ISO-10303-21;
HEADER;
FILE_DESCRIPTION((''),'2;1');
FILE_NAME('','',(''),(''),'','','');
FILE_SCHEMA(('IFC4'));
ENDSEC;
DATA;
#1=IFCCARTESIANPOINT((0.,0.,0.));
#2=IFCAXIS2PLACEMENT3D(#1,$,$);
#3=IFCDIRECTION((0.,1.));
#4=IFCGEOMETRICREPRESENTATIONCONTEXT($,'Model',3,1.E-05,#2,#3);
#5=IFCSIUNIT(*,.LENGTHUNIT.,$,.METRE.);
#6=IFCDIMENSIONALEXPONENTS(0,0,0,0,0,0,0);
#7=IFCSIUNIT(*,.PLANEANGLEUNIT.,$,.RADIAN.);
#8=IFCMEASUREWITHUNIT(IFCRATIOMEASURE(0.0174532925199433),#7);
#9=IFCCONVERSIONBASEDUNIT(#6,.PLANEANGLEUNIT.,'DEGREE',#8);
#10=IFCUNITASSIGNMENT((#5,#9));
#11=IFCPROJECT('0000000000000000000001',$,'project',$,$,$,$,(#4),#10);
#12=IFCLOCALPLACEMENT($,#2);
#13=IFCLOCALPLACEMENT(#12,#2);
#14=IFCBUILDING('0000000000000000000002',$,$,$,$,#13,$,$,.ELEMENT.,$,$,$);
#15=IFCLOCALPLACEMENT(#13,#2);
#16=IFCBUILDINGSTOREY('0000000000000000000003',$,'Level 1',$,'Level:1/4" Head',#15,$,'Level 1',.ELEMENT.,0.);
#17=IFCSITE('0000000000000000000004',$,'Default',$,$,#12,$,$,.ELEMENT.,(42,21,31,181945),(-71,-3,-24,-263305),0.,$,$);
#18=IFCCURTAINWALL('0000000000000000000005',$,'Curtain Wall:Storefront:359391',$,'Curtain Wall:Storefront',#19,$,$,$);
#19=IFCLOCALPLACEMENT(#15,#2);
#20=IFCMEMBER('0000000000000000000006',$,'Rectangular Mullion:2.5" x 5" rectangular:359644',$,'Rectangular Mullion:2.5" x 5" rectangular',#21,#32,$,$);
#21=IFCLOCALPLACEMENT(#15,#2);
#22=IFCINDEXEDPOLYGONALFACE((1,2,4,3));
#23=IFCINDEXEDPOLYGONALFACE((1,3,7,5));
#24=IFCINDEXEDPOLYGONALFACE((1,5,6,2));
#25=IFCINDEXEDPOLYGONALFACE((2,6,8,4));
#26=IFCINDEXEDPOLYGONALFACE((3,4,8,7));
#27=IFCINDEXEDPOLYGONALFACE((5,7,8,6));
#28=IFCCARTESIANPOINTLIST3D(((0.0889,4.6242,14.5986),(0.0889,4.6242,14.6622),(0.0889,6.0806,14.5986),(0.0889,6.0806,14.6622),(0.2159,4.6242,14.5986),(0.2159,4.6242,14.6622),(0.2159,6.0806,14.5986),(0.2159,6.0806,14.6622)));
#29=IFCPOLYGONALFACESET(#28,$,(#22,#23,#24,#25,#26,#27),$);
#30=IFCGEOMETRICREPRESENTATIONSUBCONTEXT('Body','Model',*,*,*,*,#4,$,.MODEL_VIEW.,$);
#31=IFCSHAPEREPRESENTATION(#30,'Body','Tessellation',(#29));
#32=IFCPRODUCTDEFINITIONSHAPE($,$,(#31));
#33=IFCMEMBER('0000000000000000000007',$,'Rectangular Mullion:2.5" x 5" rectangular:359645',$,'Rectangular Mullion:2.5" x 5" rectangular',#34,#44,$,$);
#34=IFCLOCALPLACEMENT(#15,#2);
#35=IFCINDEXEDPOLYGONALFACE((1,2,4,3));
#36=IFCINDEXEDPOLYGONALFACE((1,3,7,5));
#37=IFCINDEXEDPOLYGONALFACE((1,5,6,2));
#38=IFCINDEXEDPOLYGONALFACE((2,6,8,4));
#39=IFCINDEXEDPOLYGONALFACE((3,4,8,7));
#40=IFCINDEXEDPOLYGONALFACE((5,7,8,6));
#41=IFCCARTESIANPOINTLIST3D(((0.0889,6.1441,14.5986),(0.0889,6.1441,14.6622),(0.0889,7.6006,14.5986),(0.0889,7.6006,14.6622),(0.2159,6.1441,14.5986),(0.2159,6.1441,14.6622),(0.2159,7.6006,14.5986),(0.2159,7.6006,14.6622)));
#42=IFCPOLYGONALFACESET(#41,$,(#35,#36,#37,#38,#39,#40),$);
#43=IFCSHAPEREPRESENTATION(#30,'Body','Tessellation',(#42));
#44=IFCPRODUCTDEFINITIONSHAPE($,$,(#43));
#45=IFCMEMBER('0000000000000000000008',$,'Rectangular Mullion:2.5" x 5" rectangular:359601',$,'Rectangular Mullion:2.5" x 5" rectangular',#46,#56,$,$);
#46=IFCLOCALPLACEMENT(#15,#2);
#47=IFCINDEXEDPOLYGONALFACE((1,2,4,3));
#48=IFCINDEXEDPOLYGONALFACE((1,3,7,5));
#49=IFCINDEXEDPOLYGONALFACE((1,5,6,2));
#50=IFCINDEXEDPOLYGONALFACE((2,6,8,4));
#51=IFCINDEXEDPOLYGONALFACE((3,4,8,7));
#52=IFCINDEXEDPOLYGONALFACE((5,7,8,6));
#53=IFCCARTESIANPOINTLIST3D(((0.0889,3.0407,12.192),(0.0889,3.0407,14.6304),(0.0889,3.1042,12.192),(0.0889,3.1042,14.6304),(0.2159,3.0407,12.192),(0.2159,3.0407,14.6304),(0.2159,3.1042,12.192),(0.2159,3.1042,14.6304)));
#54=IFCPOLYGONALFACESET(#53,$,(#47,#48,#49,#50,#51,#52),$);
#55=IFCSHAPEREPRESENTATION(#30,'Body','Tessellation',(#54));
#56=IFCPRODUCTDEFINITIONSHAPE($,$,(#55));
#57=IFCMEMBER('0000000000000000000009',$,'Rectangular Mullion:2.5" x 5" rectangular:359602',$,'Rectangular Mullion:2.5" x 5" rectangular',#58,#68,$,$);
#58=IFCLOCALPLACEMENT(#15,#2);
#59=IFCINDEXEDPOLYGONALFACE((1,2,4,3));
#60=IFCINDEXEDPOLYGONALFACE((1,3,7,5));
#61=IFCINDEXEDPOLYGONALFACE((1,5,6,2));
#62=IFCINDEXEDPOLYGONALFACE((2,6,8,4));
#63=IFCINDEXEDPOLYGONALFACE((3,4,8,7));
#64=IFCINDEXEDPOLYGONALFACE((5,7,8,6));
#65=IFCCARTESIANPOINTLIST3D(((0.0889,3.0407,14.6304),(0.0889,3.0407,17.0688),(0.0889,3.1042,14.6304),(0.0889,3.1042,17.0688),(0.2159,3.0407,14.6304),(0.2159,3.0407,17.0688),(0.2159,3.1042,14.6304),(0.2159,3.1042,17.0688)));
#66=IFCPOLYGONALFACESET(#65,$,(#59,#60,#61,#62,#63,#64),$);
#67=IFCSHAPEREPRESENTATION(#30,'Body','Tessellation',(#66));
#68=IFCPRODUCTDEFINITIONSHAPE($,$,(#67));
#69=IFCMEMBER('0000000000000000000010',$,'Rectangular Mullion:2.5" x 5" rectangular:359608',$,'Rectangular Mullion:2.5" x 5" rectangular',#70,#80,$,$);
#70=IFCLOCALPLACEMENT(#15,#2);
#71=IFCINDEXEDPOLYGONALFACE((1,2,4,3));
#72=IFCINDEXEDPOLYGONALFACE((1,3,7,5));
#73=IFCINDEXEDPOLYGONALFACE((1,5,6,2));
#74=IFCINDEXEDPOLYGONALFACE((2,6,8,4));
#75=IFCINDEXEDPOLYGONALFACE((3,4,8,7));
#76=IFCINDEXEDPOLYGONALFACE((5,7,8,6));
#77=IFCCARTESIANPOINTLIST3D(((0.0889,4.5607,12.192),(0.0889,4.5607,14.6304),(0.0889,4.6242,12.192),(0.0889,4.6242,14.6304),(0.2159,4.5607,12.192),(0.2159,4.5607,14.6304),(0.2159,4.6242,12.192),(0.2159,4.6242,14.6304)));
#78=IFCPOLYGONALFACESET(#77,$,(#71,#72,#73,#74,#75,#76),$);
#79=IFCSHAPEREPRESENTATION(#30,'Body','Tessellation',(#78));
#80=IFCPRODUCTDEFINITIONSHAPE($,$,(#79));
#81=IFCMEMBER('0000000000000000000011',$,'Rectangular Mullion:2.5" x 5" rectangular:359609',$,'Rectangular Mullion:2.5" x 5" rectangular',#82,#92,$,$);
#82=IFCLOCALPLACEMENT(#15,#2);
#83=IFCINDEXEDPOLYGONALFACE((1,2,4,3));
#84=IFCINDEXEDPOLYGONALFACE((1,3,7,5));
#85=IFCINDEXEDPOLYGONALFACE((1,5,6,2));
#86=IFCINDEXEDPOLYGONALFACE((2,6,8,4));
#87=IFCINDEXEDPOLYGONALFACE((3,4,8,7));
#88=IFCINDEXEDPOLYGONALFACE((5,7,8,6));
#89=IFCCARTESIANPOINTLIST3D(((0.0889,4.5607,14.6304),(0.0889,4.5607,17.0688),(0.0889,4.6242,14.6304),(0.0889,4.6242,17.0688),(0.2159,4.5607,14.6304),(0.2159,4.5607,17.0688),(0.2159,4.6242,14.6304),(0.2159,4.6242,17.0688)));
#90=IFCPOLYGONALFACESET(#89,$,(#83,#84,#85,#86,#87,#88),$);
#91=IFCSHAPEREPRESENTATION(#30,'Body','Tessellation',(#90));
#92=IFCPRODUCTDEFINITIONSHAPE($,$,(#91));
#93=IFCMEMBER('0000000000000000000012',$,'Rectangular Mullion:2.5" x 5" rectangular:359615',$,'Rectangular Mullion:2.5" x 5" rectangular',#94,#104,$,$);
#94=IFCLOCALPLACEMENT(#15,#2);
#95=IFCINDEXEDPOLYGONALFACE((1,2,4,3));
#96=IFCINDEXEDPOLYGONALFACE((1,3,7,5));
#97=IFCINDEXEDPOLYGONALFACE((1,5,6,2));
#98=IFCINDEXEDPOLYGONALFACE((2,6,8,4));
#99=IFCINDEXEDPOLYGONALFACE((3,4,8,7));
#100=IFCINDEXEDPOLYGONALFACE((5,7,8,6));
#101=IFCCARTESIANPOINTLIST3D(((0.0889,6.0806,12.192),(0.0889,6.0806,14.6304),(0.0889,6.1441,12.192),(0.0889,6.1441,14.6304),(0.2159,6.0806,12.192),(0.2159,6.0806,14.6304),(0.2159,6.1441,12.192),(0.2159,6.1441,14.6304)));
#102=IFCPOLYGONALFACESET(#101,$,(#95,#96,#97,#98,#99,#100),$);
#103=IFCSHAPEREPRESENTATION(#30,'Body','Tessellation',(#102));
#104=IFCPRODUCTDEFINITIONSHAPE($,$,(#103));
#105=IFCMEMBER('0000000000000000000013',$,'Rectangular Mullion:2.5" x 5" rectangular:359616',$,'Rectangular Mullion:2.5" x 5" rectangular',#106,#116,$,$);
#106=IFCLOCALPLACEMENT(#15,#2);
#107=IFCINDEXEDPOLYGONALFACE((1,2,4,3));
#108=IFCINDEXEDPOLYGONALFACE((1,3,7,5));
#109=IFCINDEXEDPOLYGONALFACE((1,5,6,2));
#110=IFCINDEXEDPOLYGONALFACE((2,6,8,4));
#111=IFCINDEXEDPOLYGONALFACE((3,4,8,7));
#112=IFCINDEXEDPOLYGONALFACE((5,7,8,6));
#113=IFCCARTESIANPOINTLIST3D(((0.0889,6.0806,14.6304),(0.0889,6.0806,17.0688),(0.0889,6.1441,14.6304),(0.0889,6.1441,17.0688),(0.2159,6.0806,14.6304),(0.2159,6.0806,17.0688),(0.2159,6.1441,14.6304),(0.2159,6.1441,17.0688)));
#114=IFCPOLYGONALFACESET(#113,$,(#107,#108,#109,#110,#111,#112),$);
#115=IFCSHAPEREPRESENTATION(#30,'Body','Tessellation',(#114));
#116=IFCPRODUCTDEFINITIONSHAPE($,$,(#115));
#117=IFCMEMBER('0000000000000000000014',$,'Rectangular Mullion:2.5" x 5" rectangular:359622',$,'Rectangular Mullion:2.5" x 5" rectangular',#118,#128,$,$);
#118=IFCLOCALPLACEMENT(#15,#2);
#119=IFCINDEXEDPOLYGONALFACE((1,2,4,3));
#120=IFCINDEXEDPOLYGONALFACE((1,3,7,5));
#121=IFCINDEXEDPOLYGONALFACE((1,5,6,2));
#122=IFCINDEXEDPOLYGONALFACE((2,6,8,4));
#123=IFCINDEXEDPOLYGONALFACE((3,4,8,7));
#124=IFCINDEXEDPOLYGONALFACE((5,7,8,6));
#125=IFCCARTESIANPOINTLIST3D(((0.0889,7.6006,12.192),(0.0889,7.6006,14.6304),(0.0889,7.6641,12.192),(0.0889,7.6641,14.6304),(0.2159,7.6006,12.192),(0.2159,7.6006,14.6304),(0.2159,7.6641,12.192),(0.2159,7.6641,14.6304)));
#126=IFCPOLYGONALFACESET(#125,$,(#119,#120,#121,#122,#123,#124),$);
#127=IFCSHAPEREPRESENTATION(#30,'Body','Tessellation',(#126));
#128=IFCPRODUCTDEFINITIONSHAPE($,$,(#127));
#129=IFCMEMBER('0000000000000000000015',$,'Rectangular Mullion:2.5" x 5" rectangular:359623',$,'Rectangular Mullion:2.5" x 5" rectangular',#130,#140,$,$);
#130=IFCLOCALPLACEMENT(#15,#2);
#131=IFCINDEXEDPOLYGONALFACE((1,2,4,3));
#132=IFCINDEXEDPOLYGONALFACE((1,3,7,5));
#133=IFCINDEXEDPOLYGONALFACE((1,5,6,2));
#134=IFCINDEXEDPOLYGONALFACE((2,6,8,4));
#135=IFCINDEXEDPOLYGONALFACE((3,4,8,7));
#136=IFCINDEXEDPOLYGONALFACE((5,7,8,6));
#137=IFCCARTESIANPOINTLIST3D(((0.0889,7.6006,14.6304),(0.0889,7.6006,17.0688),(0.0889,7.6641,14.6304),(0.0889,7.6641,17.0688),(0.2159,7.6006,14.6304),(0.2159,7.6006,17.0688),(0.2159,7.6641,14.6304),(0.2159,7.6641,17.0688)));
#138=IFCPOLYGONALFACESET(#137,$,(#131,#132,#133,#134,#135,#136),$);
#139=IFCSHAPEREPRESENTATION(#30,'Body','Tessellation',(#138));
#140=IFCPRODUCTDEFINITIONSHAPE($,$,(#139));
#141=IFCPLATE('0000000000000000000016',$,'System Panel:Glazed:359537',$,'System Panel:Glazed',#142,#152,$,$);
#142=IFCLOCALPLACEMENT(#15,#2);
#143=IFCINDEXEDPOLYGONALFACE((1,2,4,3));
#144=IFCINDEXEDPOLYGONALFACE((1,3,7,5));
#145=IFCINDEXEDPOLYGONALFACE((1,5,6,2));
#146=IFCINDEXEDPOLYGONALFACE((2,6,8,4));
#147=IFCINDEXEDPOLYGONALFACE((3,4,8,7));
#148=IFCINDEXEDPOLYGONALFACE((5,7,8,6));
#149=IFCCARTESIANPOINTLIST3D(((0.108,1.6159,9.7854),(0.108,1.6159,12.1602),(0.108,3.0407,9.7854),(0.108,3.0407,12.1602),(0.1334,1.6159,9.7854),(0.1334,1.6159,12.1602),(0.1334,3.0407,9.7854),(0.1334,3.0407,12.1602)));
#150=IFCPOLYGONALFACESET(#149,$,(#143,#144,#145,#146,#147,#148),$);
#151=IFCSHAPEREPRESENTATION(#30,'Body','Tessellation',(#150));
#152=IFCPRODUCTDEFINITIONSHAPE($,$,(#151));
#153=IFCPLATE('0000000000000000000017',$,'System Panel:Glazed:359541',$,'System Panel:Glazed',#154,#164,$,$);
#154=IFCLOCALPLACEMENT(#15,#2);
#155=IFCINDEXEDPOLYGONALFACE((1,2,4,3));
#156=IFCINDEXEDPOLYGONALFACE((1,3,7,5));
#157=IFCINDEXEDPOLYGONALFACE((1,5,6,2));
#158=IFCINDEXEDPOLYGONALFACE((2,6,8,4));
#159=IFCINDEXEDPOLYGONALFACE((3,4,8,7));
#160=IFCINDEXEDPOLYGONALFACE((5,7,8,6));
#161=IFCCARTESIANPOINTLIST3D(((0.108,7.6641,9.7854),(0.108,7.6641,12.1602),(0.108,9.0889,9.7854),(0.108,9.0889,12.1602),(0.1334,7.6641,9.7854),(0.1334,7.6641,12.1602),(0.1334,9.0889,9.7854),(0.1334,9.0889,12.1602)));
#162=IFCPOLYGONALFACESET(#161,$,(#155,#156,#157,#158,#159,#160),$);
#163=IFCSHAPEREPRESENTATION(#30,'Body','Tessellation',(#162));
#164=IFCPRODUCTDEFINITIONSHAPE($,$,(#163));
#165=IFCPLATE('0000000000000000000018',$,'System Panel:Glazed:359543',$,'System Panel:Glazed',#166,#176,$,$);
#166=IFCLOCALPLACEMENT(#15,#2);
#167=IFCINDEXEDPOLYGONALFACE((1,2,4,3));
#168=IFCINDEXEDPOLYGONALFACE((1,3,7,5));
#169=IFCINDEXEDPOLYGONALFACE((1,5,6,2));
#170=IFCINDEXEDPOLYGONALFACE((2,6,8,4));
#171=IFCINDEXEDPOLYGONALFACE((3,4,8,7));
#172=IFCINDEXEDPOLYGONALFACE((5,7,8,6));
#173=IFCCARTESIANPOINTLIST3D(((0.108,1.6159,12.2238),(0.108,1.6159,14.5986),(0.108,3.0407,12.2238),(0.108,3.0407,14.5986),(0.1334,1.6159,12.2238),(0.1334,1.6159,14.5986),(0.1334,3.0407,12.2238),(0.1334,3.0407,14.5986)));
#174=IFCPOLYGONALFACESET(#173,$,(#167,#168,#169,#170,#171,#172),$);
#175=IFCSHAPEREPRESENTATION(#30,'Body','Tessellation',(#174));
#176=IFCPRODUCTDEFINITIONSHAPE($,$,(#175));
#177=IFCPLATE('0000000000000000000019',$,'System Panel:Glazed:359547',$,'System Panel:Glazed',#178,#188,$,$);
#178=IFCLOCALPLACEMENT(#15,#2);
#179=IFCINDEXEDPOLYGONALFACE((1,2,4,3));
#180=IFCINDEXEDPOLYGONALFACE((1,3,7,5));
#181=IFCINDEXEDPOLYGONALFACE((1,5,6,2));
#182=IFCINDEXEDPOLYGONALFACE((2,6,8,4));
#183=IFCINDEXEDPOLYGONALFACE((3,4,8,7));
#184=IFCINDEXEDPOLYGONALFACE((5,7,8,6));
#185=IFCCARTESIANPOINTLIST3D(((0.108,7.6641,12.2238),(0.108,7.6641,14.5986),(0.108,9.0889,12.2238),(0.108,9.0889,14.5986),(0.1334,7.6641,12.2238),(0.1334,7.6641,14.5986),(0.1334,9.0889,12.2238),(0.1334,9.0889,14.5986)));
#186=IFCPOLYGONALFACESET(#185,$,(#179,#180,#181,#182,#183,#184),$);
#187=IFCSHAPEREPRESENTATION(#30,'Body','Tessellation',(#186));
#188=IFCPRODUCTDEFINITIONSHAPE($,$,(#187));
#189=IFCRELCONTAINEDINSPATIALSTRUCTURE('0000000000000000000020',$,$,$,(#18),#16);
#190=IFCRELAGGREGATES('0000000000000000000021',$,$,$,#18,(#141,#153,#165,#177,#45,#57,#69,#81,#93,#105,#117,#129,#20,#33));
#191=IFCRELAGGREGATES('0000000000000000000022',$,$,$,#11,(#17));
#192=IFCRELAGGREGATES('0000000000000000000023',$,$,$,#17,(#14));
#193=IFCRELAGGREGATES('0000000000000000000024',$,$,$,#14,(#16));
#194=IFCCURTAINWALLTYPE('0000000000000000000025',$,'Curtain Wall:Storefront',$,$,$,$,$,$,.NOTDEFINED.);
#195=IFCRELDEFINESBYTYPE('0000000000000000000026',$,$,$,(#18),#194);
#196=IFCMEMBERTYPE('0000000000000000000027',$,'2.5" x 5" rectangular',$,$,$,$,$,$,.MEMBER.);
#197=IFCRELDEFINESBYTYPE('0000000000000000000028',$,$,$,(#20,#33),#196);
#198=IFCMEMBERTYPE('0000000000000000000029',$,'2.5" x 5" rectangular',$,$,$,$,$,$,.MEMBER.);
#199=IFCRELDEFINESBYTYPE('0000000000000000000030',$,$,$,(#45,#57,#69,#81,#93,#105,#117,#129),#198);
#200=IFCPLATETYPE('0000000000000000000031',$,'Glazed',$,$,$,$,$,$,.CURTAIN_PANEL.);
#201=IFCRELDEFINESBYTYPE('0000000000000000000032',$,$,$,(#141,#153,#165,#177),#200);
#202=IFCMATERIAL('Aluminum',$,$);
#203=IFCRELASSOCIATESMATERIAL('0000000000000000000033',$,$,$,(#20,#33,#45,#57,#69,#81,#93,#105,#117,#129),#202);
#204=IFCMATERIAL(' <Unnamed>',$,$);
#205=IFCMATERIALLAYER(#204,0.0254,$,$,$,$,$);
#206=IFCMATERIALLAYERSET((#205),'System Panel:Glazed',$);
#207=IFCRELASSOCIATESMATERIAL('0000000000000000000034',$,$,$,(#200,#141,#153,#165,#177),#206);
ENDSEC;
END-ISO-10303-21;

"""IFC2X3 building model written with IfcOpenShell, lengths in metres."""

from ifc_helpers import new_model, entity, si_unit, converted_unit, direction, frame, frame_2d, origin, origin_2d_with_axis, place, context, subcontext, project, spatial, rectangle, extrude, source, transform, mapped, material, layer, layer_set, layer_usage, type_object, type_shapes, element, aggregate, save


model = new_model("IFC2X3")

# Units and contexts
model_context = context("Model", 3, precision=1e-05, world=origin(), true_north=direction((0.0, 1.0)))
body_context = subcontext(model_context, "Body", "Model", "MODEL_VIEW")
ifc_project = project(units=[si_unit("LENGTHUNIT", "METRE"), converted_unit("PLANEANGLEUNIT", "DEGREE", entity("IfcRatioMeasure", 0.0174532925199433), si_unit("PLANEANGLEUNIT", "RADIAN"), dimensions=[0, 0, 0, 0, 0, 0, 0])], contexts=[model_context])

# Site, building, storey
site_placement = place(None, origin())
site = spatial("IfcSite", under=ifc_project, at=site_placement, Name="Default", CompositionType="ELEMENT", RefLatitude=(42, 21, 31, 181945), RefLongitude=(-71, -3, -24, -263305), RefElevation=0.0)
building_placement = place(site_placement, origin())
building = spatial("IfcBuilding", under=site, at=building_placement, CompositionType="ELEMENT")
storey_placement = place(building_placement, origin())
storey = spatial("IfcBuildingStorey", under=building, at=storey_placement, Name="Level 1", ObjectType="Level:1/4\" Head", LongName="Level 1", CompositionType="ELEMENT", Elevation=0.0)

# Curtain wall, members, plates
curtain_wall_type = type_object("IfcCurtainWallType", Name="Curtain Wall:Storefront", PredefinedType="NOTDEFINED")
curtain_wall_placement = place(storey_placement, origin())
curtain_wall = element("IfcCurtainWall", 1, at=curtain_wall_placement, inside=storey, type_object=curtain_wall_type, Name="Curtain Wall:Storefront:359391", ObjectType="Curtain Wall:Storefront")
ifc_material_1 = material(Name="Aluminum")
member_type_1 = type_object("IfcMemberType", Name="2.5\" x 5\" rectangular", PredefinedType="MEMBER")
shared_shape_1 = source(origin(), body_context, "Body", "SweptSolid", [
    extrude(rectangle(XDim=0.127, YDim=0.0635, at=origin_2d_with_axis()), frame((0.0, 0.0, -1.4565), z_axis=(0.0, 0.0, 1.0), x_axis=(0.0, -1.0, 0.0)), (0.0, 0.0, 1.0), 1.4565),
])
type_shapes(member_type_1, [shared_shape_1])
member_1_placement = place(storey_placement, frame((0.1524, 6.0806, 14.6304), z_axis=(0.0, 1.0, 0.0), x_axis=(0.0, 0.0, 1.0)))
member_1 = element("IfcMember", 2, at=member_1_placement, type_object=member_type_1, material=ifc_material_1, Name="Rectangular Mullion:2.5\" x 5\" rectangular:359644", ObjectType="Rectangular Mullion:2.5\" x 5\" rectangular", context=body_context, shape_type="MappedRepresentation", body=[
    mapped(shared_shape_1, transform((0.0, 0.0, 0.0), scale=1.0)),
])
member_2_placement = place(storey_placement, frame((0.1524, 7.6006, 14.6304), z_axis=(0.0, 1.0, 0.0), x_axis=(0.0, 0.0, 1.0)))
member_2 = element("IfcMember", 3, at=member_2_placement, type_object=member_type_1, material=ifc_material_1, Name="Rectangular Mullion:2.5\" x 5\" rectangular:359645", ObjectType="Rectangular Mullion:2.5\" x 5\" rectangular", context=body_context, shape_type="MappedRepresentation", body=[
    mapped(shared_shape_1, transform((0.0, 0.0, 0.0), scale=1.0)),
])
member_type_2 = type_object("IfcMemberType", Name="2.5\" x 5\" rectangular", PredefinedType="MEMBER")
shared_shape_2 = source(origin(), body_context, "Body", "SweptSolid", [
    extrude(rectangle(XDim=0.127, YDim=0.0635, at=origin_2d_with_axis()), frame((0.0, 0.0, -2.4384), z_axis=(0.0, 0.0, 1.0), x_axis=(0.0, -1.0, 0.0)), (0.0, 0.0, 1.0), 2.4384),
])
type_shapes(member_type_2, [shared_shape_2])
member_3_placement = place(storey_placement, frame((0.1524, 3.0724, 12.192), z_axis=(0.0, 0.0, -1.0), x_axis=(0.0, 1.0, 0.0)))
member_3 = element("IfcMember", 4, at=member_3_placement, type_object=member_type_2, material=ifc_material_1, Name="Rectangular Mullion:2.5\" x 5\" rectangular:359601", ObjectType="Rectangular Mullion:2.5\" x 5\" rectangular", context=body_context, shape_type="MappedRepresentation", body=[
    mapped(shared_shape_2, transform((0.0, 0.0, 0.0), scale=1.0)),
])
member_4_placement = place(storey_placement, frame((0.1524, 3.0724, 14.6304), z_axis=(0.0, 0.0, -1.0), x_axis=(0.0, 1.0, 0.0)))
member_4 = element("IfcMember", 5, at=member_4_placement, type_object=member_type_2, material=ifc_material_1, Name="Rectangular Mullion:2.5\" x 5\" rectangular:359602", ObjectType="Rectangular Mullion:2.5\" x 5\" rectangular", context=body_context, shape_type="MappedRepresentation", body=[
    mapped(shared_shape_2, transform((0.0, 0.0, 0.0), scale=1.0)),
])
member_5_placement = place(storey_placement, frame((0.1524, 4.5924, 12.192), z_axis=(0.0, 0.0, -1.0), x_axis=(0.0, 1.0, 0.0)))
member_5 = element("IfcMember", 6, at=member_5_placement, type_object=member_type_2, material=ifc_material_1, Name="Rectangular Mullion:2.5\" x 5\" rectangular:359608", ObjectType="Rectangular Mullion:2.5\" x 5\" rectangular", context=body_context, shape_type="MappedRepresentation", body=[
    mapped(shared_shape_2, transform((0.0, 0.0, 0.0), scale=1.0)),
])
member_6_placement = place(storey_placement, frame((0.1524, 4.5924, 14.6304), z_axis=(0.0, 0.0, -1.0), x_axis=(0.0, 1.0, 0.0)))
member_6 = element("IfcMember", 7, at=member_6_placement, type_object=member_type_2, material=ifc_material_1, Name="Rectangular Mullion:2.5\" x 5\" rectangular:359609", ObjectType="Rectangular Mullion:2.5\" x 5\" rectangular", context=body_context, shape_type="MappedRepresentation", body=[
    mapped(shared_shape_2, transform((0.0, 0.0, 0.0), scale=1.0)),
])
member_7_placement = place(storey_placement, frame((0.1524, 6.1124, 12.192), z_axis=(0.0, 0.0, -1.0), x_axis=(0.0, 1.0, 0.0)))
member_7 = element("IfcMember", 8, at=member_7_placement, type_object=member_type_2, material=ifc_material_1, Name="Rectangular Mullion:2.5\" x 5\" rectangular:359615", ObjectType="Rectangular Mullion:2.5\" x 5\" rectangular", context=body_context, shape_type="MappedRepresentation", body=[
    mapped(shared_shape_2, transform((0.0, 0.0, 0.0), scale=1.0)),
])
member_8_placement = place(storey_placement, frame((0.1524, 6.1124, 14.6304), z_axis=(0.0, 0.0, -1.0), x_axis=(0.0, 1.0, 0.0)))
member_8 = element("IfcMember", 9, at=member_8_placement, type_object=member_type_2, material=ifc_material_1, Name="Rectangular Mullion:2.5\" x 5\" rectangular:359616", ObjectType="Rectangular Mullion:2.5\" x 5\" rectangular", context=body_context, shape_type="MappedRepresentation", body=[
    mapped(shared_shape_2, transform((0.0, 0.0, 0.0), scale=1.0)),
])
member_9_placement = place(storey_placement, frame((0.1524, 7.6324, 12.192), z_axis=(0.0, 0.0, -1.0), x_axis=(0.0, 1.0, 0.0)))
member_9 = element("IfcMember", 10, at=member_9_placement, type_object=member_type_2, material=ifc_material_1, Name="Rectangular Mullion:2.5\" x 5\" rectangular:359622", ObjectType="Rectangular Mullion:2.5\" x 5\" rectangular", context=body_context, shape_type="MappedRepresentation", body=[
    mapped(shared_shape_2, transform((0.0, 0.0, 0.0), scale=1.0)),
])
member_10_placement = place(storey_placement, frame((0.1524, 7.6324, 14.6304), z_axis=(0.0, 0.0, -1.0), x_axis=(0.0, 1.0, 0.0)))
member_10 = element("IfcMember", 11, at=member_10_placement, type_object=member_type_2, material=ifc_material_1, Name="Rectangular Mullion:2.5\" x 5\" rectangular:359623", ObjectType="Rectangular Mullion:2.5\" x 5\" rectangular", context=body_context, shape_type="MappedRepresentation", body=[
    mapped(shared_shape_2, transform((0.0, 0.0, 0.0), scale=1.0)),
])
ifc_material_2 = material(Name=" <Unnamed>")
ifc_layer = layer(ifc_material_2, 0.0254)
ifc_layer_set = layer_set([ifc_layer], Name="System Panel:Glazed")
ifc_layer_usage_1 = layer_usage(ifc_layer_set, "AXIS3", "POSITIVE", 0.1042)
plate_type_1 = type_object("IfcPlateType", Name="Glazed", PredefinedType="CURTAIN_PANEL", material=ifc_layer_set)
shared_shape_3 = source(origin(), body_context, "Body", "SweptSolid", [
    extrude(rectangle(XDim=0.0254, YDim=1.4248, at=frame_2d((0.0, 0.0), x_axis=(1.0, 0.0))), frame((0.7124, 0.0127, 0.0), z_axis=(0.0, 0.0, 1.0), x_axis=(0.0, 1.0, 0.0)), (0.0, 0.0, 1.0), 2.3749),
])
type_shapes(plate_type_1, [shared_shape_3])
plate_1_placement = place(curtain_wall_placement, frame((0.1334, 1.6159, 9.7853), z_axis=(0.0, 0.0, 1.0), x_axis=(0.0, 1.0, 0.0)))
plate_1 = element("IfcPlate", 12, at=plate_1_placement, type_object=plate_type_1, material=ifc_layer_usage_1, Name="System Panel:Glazed:359537", ObjectType="System Panel:Glazed", context=body_context, shape_type="MappedRepresentation", body=[
    mapped(shared_shape_3, transform((0.0, 0.0, 0.0), scale=1.0)),
])
ifc_layer_usage_2 = layer_usage(ifc_layer_set, "AXIS3", "POSITIVE", 0.1042)
plate_2_placement = place(curtain_wall_placement, frame((0.1334, 7.6641, 9.7853), z_axis=(0.0, 0.0, 1.0), x_axis=(0.0, 1.0, 0.0)))
plate_2 = element("IfcPlate", 13, at=plate_2_placement, type_object=plate_type_1, material=ifc_layer_usage_2, Name="System Panel:Glazed:359541", ObjectType="System Panel:Glazed", context=body_context, shape_type="MappedRepresentation", body=[
    mapped(shared_shape_3, transform((0.0, 0.0, 0.0), scale=1.0)),
])
ifc_layer_usage_3 = layer_usage(ifc_layer_set, "AXIS3", "POSITIVE", 0.1042)
plate_3_placement = place(curtain_wall_placement, frame((0.1334, 1.6159, 12.2238), z_axis=(0.0, 0.0, 1.0), x_axis=(0.0, 1.0, 0.0)))
plate_3 = element("IfcPlate", 14, at=plate_3_placement, type_object=plate_type_1, material=ifc_layer_usage_3, Name="System Panel:Glazed:359543", ObjectType="System Panel:Glazed", context=body_context, shape_type="MappedRepresentation", body=[
    mapped(shared_shape_3, transform((0.0, 0.0, 0.0), scale=1.0)),
])
ifc_layer_usage_4 = layer_usage(ifc_layer_set, "AXIS3", "POSITIVE", 0.1042)
plate_4_placement = place(curtain_wall_placement, frame((0.1334, 7.6641, 12.2238), z_axis=(0.0, 0.0, 1.0), x_axis=(0.0, 1.0, 0.0)))
plate_4 = element("IfcPlate", 15, at=plate_4_placement, type_object=plate_type_1, material=ifc_layer_usage_4, Name="System Panel:Glazed:359547", ObjectType="System Panel:Glazed", context=body_context, shape_type="MappedRepresentation", body=[
    mapped(shared_shape_3, transform((0.0, 0.0, 0.0), scale=1.0)),
])
aggregate(curtain_wall, [plate_1, plate_2, plate_3, plate_4, member_3, member_4, member_5, member_6, member_7, member_8, member_9, member_10, member_1, member_2])

save(model, "model.ifc")
